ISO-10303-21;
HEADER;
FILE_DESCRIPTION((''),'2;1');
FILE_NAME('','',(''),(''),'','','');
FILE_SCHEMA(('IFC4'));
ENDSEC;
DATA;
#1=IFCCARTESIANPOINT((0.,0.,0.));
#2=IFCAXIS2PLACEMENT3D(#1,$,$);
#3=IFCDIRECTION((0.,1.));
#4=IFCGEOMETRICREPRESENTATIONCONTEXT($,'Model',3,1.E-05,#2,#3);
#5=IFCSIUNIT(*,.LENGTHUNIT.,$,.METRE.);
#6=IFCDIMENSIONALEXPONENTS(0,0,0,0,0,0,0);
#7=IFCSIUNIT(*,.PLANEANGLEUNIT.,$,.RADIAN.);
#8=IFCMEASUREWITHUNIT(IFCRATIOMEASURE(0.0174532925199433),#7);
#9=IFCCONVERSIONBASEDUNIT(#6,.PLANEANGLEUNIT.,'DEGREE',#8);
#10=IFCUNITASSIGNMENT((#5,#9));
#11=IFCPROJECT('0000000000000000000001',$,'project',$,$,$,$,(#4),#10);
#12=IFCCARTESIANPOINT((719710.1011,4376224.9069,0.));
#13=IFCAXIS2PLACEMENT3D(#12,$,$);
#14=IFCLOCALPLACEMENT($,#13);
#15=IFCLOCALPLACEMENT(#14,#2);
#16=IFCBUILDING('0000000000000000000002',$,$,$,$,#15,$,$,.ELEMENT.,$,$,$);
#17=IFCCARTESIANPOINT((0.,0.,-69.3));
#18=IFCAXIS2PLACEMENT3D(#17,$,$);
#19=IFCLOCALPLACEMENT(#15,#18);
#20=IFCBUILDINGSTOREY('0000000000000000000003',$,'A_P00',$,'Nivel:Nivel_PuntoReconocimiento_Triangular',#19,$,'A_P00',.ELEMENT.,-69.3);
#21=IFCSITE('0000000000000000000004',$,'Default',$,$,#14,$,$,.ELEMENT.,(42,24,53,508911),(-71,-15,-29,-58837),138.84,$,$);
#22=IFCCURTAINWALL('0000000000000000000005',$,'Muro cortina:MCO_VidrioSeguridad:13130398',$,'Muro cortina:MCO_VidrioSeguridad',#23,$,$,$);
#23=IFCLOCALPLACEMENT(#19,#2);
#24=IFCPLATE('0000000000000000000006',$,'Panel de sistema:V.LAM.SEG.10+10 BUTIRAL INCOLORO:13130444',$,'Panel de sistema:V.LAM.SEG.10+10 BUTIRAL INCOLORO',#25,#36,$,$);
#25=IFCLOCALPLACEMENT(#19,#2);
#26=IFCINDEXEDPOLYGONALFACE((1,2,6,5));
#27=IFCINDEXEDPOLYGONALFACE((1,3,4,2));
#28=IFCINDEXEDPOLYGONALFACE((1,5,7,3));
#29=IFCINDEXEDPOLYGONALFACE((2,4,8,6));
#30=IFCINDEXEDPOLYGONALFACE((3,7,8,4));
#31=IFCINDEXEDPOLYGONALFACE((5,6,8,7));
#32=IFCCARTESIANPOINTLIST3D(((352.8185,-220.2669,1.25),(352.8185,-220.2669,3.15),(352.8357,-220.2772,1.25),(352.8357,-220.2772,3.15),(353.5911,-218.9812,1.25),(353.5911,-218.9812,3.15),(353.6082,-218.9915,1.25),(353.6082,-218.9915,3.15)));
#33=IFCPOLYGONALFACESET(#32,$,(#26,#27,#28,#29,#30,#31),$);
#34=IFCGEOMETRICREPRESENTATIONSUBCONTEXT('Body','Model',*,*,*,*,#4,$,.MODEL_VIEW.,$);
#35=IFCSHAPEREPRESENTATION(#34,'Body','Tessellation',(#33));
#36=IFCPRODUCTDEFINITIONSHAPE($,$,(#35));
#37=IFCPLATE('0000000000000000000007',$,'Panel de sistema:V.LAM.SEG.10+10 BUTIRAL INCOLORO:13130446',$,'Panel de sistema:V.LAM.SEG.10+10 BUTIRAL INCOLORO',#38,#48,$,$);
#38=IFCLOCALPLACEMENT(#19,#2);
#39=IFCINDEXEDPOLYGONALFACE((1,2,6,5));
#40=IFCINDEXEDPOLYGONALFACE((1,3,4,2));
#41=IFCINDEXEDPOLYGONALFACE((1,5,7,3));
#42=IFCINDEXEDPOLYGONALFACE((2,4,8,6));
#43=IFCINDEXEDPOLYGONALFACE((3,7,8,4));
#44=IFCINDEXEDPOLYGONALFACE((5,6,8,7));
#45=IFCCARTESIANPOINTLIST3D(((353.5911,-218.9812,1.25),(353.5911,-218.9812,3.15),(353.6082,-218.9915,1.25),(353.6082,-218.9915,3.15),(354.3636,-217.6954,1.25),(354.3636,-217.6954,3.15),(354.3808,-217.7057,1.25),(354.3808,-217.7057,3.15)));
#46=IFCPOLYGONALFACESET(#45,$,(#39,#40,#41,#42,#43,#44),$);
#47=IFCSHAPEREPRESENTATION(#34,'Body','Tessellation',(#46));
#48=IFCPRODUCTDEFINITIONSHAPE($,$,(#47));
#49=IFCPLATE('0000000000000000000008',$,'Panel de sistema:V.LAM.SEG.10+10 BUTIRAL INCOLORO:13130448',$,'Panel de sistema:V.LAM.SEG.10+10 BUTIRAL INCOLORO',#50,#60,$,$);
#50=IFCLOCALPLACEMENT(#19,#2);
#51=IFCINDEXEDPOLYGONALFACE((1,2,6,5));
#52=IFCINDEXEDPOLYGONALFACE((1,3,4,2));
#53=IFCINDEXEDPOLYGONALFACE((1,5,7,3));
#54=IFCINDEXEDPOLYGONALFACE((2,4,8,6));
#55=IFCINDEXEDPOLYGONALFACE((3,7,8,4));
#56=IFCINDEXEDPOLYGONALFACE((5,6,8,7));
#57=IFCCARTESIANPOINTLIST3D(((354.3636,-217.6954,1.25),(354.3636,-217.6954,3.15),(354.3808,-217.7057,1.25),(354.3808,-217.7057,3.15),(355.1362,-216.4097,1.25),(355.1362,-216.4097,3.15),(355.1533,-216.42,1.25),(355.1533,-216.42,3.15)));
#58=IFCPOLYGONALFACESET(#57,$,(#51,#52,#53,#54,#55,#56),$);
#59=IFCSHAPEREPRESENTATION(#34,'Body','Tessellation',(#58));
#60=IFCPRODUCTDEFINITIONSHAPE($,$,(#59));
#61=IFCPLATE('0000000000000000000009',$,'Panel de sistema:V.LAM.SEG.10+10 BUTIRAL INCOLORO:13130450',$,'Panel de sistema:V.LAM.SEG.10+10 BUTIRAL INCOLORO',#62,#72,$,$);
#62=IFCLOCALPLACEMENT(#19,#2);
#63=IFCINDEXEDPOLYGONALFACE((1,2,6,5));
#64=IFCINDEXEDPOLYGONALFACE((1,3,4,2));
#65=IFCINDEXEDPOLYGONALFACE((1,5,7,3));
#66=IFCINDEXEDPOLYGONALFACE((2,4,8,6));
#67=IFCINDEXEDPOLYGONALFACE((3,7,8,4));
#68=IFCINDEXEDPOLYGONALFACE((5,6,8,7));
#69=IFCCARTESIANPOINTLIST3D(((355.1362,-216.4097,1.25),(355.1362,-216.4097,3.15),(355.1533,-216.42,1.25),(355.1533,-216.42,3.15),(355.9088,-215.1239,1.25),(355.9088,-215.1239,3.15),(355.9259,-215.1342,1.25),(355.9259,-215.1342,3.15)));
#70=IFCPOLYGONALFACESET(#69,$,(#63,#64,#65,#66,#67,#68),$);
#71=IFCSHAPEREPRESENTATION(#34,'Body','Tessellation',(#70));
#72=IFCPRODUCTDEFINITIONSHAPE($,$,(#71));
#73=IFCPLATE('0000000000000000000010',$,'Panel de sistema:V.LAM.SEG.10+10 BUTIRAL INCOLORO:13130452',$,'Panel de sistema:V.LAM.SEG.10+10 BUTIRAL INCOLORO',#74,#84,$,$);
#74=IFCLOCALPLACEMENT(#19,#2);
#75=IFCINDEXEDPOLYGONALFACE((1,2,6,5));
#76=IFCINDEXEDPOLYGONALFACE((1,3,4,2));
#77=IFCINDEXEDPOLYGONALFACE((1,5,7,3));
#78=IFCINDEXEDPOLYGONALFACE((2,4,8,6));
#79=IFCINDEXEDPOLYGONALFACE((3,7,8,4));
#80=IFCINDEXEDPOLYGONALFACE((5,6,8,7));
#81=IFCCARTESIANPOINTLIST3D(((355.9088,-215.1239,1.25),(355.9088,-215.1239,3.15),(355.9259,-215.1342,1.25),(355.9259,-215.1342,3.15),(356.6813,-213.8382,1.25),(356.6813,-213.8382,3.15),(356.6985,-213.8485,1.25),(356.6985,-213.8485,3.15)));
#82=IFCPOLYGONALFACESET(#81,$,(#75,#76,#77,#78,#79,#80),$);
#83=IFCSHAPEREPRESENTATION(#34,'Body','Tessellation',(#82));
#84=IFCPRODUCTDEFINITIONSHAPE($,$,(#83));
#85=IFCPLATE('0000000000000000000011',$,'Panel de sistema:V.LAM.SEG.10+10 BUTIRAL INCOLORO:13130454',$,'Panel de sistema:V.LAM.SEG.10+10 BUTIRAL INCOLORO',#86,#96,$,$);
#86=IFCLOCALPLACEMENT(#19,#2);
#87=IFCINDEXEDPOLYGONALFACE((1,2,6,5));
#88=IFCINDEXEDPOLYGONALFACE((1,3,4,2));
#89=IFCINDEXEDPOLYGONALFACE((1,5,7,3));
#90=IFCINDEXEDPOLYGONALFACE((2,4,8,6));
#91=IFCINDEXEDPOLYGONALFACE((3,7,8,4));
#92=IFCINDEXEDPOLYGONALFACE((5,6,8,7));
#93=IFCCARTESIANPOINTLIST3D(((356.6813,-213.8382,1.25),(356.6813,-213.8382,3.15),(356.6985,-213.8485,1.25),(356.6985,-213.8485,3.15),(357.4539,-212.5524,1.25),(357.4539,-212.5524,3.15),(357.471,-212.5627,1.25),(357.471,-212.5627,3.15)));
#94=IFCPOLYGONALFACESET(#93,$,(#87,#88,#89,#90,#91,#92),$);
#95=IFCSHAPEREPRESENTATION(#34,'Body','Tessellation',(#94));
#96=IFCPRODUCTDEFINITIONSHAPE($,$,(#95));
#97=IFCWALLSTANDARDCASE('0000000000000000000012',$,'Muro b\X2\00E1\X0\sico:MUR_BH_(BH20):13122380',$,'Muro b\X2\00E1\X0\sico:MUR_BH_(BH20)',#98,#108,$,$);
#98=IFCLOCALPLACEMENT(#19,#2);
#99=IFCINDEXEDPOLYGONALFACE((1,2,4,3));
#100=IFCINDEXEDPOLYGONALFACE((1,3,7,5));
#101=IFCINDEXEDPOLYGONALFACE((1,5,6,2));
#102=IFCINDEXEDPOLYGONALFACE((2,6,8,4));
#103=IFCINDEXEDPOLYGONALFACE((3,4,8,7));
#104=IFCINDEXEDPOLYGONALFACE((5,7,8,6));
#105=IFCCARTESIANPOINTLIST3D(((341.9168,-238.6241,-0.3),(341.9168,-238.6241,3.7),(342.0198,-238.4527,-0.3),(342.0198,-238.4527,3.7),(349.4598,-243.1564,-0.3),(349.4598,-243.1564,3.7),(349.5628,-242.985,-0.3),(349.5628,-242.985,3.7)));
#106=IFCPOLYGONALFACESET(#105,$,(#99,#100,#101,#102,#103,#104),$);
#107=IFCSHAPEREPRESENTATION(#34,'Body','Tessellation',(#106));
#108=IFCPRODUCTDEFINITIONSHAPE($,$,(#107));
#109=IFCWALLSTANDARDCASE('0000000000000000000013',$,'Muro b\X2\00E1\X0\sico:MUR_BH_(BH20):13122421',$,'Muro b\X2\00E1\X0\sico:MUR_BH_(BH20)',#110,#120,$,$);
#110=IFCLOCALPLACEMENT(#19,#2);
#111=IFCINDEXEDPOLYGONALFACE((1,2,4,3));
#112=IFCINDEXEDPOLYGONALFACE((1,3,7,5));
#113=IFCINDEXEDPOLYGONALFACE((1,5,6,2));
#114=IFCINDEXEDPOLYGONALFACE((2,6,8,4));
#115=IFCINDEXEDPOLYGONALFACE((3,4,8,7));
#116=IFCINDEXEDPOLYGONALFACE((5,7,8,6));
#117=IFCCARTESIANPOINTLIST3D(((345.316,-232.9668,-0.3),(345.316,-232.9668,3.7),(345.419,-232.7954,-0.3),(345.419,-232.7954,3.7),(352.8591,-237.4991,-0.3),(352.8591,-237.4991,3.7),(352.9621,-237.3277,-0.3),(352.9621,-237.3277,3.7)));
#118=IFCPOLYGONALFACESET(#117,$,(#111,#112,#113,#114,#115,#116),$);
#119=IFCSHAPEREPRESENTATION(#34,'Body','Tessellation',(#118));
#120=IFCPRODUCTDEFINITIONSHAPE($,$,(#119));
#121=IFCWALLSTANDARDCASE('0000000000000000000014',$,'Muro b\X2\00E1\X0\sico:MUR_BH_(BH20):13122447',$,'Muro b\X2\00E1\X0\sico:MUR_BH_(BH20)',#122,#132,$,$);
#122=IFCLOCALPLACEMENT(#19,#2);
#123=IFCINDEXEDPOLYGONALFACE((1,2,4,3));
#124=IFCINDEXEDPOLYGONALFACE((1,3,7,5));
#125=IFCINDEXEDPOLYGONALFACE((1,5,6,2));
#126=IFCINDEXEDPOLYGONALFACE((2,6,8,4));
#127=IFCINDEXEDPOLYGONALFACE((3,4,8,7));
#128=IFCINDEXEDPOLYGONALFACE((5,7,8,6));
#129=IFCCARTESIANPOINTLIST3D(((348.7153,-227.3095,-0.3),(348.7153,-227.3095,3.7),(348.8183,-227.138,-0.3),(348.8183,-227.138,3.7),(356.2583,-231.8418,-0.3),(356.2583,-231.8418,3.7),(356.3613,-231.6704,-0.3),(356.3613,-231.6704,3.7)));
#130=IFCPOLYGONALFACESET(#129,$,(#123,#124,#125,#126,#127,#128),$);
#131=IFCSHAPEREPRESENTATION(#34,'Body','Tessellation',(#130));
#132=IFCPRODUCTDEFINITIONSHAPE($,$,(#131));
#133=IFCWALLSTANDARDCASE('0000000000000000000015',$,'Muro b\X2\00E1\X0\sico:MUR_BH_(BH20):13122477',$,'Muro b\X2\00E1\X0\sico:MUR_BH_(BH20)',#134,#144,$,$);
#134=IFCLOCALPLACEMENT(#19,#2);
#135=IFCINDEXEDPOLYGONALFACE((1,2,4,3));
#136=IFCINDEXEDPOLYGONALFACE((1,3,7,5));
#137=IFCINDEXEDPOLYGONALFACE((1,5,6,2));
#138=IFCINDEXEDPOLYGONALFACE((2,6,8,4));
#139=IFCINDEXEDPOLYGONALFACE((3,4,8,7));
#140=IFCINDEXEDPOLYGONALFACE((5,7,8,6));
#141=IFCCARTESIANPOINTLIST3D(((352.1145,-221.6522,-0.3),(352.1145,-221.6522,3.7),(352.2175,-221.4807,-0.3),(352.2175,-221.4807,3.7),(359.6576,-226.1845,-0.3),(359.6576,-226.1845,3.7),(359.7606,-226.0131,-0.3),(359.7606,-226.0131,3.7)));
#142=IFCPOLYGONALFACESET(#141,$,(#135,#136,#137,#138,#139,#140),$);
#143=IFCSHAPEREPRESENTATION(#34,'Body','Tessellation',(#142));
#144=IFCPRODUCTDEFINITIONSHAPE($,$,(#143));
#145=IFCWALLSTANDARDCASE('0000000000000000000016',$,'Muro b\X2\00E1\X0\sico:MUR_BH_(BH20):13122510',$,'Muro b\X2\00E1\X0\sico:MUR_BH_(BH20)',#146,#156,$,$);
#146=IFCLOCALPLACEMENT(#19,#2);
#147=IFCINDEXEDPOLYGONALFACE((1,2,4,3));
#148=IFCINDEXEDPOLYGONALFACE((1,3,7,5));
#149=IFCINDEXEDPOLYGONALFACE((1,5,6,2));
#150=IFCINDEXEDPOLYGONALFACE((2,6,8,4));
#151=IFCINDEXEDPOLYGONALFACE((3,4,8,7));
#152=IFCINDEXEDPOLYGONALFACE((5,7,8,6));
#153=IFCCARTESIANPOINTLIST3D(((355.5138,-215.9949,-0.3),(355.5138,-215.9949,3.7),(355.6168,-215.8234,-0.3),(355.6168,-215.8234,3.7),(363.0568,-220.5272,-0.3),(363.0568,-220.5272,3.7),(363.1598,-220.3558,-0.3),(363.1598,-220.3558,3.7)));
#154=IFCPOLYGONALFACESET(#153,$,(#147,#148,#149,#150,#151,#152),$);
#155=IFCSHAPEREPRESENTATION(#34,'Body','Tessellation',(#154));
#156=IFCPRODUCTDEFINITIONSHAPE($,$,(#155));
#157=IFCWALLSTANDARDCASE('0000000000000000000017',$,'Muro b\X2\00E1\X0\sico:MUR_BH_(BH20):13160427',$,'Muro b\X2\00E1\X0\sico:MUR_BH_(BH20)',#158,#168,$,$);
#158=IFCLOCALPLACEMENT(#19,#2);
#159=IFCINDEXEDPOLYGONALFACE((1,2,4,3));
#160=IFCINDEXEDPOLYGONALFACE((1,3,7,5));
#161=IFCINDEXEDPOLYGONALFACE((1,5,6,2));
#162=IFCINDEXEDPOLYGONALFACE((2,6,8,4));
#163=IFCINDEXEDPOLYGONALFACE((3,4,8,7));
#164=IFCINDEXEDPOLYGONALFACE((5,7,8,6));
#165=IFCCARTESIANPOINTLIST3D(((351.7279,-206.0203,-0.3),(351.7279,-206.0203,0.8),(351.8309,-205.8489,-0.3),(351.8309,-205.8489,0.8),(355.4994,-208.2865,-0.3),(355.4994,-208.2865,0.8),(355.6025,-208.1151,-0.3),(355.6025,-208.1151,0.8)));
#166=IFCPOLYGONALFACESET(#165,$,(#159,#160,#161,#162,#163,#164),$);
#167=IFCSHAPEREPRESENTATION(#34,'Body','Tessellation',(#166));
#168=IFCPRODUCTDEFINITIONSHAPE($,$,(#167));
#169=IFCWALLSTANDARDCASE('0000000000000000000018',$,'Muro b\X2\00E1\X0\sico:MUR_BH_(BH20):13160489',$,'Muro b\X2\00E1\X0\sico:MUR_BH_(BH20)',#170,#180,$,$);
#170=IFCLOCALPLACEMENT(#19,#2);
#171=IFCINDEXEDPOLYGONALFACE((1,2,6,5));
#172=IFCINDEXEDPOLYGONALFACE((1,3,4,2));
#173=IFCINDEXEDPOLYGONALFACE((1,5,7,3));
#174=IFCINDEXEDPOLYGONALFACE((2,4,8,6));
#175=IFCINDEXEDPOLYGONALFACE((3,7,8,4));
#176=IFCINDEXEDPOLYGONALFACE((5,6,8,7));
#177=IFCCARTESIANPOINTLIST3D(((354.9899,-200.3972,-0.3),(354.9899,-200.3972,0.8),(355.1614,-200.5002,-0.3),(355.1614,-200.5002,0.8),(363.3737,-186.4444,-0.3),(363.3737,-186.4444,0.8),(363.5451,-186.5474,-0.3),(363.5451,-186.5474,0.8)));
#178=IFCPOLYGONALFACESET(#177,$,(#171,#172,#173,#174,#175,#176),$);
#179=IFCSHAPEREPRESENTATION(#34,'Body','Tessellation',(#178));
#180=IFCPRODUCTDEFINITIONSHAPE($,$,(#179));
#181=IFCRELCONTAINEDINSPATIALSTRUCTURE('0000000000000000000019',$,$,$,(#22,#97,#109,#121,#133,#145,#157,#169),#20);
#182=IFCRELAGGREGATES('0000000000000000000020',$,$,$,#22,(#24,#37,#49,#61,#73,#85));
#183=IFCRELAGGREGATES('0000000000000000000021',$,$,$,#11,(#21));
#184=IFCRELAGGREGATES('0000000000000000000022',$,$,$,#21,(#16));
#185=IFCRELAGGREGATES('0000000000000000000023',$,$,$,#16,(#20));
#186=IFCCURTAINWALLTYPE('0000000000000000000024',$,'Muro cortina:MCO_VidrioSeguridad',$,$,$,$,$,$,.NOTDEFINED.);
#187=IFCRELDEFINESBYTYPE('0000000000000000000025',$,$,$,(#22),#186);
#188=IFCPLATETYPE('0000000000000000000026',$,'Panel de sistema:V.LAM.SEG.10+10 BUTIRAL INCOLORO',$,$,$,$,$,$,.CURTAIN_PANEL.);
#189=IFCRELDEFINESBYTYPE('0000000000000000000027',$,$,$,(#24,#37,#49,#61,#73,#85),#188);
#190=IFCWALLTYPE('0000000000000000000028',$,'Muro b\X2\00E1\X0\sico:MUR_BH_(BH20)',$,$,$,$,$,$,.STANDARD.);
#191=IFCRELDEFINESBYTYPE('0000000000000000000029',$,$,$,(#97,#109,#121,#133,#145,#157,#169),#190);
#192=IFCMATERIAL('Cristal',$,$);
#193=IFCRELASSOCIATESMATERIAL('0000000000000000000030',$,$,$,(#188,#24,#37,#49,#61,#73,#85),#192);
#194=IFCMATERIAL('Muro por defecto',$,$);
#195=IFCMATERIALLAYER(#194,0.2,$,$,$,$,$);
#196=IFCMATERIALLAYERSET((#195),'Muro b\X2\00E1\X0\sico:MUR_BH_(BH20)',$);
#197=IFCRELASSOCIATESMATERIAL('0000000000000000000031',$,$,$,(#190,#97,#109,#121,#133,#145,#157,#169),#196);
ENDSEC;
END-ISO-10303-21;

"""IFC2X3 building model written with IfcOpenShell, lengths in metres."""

from ifc_helpers import new_model, entity, si_unit, converted_unit, direction, frame, frame_2d, origin, origin_2d_with_axis, place, context, subcontext, project, spatial, rectangle, extrude, source, transform, mapped, material, layer, layer_set, layer_usage, type_object, type_shapes, element, aggregate, save


model = new_model("IFC2X3")

# Units and contexts
model_context = context("Model", 3, precision=1e-05, world=origin(), true_north=direction((0.0, 1.0)))
body_context = subcontext(model_context, "Body", "Model", "MODEL_VIEW")
ifc_project = project(units=[si_unit("LENGTHUNIT", "METRE"), converted_unit("PLANEANGLEUNIT", "DEGREE", entity("IfcRatioMeasure", 0.0174532925199433), si_unit("PLANEANGLEUNIT", "RADIAN"), dimensions=[0, 0, 0, 0, 0, 0, 0])], contexts=[model_context])

# Site, building, storey
site_placement = place(None, frame((719710.1011, 4376224.9069, 0.0)))
site = spatial("IfcSite", under=ifc_project, at=site_placement, Name="Default", CompositionType="ELEMENT", RefLatitude=(42, 24, 53, 508911), RefLongitude=(-71, -15, -29, -58837), RefElevation=138.84)
building_placement = place(site_placement, origin())
building = spatial("IfcBuilding", under=site, at=building_placement, CompositionType="ELEMENT")
storey_placement = place(building_placement, frame((0.0, 0.0, -69.3)))
storey = spatial("IfcBuildingStorey", under=building, at=storey_placement, Name="A_P00", ObjectType="Nivel:Nivel_PuntoReconocimiento_Triangular", LongName="A_P00", CompositionType="ELEMENT", Elevation=-69.3)

# Curtain wall, plates
curtain_wall_type = type_object("IfcCurtainWallType", Name="Muro cortina:MCO_VidrioSeguridad", PredefinedType="NOTDEFINED")
curtain_wall_placement = place(storey_placement, frame((0.0, 0.0, 69.3)))
curtain_wall = element("IfcCurtainWall", 1, at=curtain_wall_placement, inside=storey, type_object=curtain_wall_type, Name="Muro cortina:MCO_VidrioSeguridad:13130398", ObjectType="Muro cortina:MCO_VidrioSeguridad")
ifc_material_1 = material(Name="Cristal")
plate_type = type_object("IfcPlateType", Name="Panel de sistema:V.LAM.SEG.10+10 BUTIRAL INCOLORO", PredefinedType="CURTAIN_PANEL", material=ifc_material_1)
shared_shape = source(origin(), body_context, "Body", "SweptSolid", [
    extrude(rectangle(XDim=0.02, YDim=1.5, at=origin_2d_with_axis()), frame((0.0, 0.0, 0.0), z_axis=(0.0, 0.0, 1.0), x_axis=(0.0, 1.0, 0.0)), (0.0, 0.0, 1.0), 1.9),
])
type_shapes(plate_type, [shared_shape])
plate_1_placement = place(curtain_wall_placement, frame((353.2134, -219.6292, -68.05), z_axis=(0.0, 0.0, 1.0), x_axis=(0.515038, 0.857167, 0.0)))
plate_1 = element("IfcPlate", 2, at=plate_1_placement, type_object=plate_type, material=ifc_material_1, Name="Panel de sistema:V.LAM.SEG.10+10 BUTIRAL INCOLORO:13130444", ObjectType="Panel de sistema:V.LAM.SEG.10+10 BUTIRAL INCOLORO", context=body_context, shape_type="MappedRepresentation", body=[
    mapped(shared_shape, transform((0.0, 0.0, 0.0), scale=1.0)),
])
plate_2_placement = place(curtain_wall_placement, frame((353.9859, -218.3434, -68.05), z_axis=(0.0, 0.0, 1.0), x_axis=(0.515038, 0.857167, 0.0)))
plate_2 = element("IfcPlate", 3, at=plate_2_placement, type_object=plate_type, material=ifc_material_1, Name="Panel de sistema:V.LAM.SEG.10+10 BUTIRAL INCOLORO:13130446", ObjectType="Panel de sistema:V.LAM.SEG.10+10 BUTIRAL INCOLORO", context=body_context, shape_type="MappedRepresentation", body=[
    mapped(shared_shape, transform((0.0, 0.0, 0.0), scale=1.0)),
])
plate_3_placement = place(curtain_wall_placement, frame((354.7585, -217.0577, -68.05), z_axis=(0.0, 0.0, 1.0), x_axis=(0.515038, 0.857167, 0.0)))
plate_3 = element("IfcPlate", 4, at=plate_3_placement, type_object=plate_type, material=ifc_material_1, Name="Panel de sistema:V.LAM.SEG.10+10 BUTIRAL INCOLORO:13130448", ObjectType="Panel de sistema:V.LAM.SEG.10+10 BUTIRAL INCOLORO", context=body_context, shape_type="MappedRepresentation", body=[
    mapped(shared_shape, transform((0.0, 0.0, 0.0), scale=1.0)),
])
plate_4_placement = place(curtain_wall_placement, frame((355.5311, -215.7719, -68.05), z_axis=(0.0, 0.0, 1.0), x_axis=(0.515038, 0.857167, 0.0)))
plate_4 = element("IfcPlate", 5, at=plate_4_placement, type_object=plate_type, material=ifc_material_1, Name="Panel de sistema:V.LAM.SEG.10+10 BUTIRAL INCOLORO:13130450", ObjectType="Panel de sistema:V.LAM.SEG.10+10 BUTIRAL INCOLORO", context=body_context, shape_type="MappedRepresentation", body=[
    mapped(shared_shape, transform((0.0, 0.0, 0.0), scale=1.0)),
])
plate_5_placement = place(curtain_wall_placement, frame((356.3036, -214.4862, -68.05), z_axis=(0.0, 0.0, 1.0), x_axis=(0.515038, 0.857167, 0.0)))
plate_5 = element("IfcPlate", 6, at=plate_5_placement, type_object=plate_type, material=ifc_material_1, Name="Panel de sistema:V.LAM.SEG.10+10 BUTIRAL INCOLORO:13130452", ObjectType="Panel de sistema:V.LAM.SEG.10+10 BUTIRAL INCOLORO", context=body_context, shape_type="MappedRepresentation", body=[
    mapped(shared_shape, transform((0.0, 0.0, 0.0), scale=1.0)),
])
plate_6_placement = place(curtain_wall_placement, frame((357.0762, -213.2004, -68.05), z_axis=(0.0, 0.0, 1.0), x_axis=(0.515038, 0.857167, 0.0)))
plate_6 = element("IfcPlate", 7, at=plate_6_placement, type_object=plate_type, material=ifc_material_1, Name="Panel de sistema:V.LAM.SEG.10+10 BUTIRAL INCOLORO:13130454", ObjectType="Panel de sistema:V.LAM.SEG.10+10 BUTIRAL INCOLORO", context=body_context, shape_type="MappedRepresentation", body=[
    mapped(shared_shape, transform((0.0, 0.0, 0.0), scale=1.0)),
])
aggregate(curtain_wall, [plate_1, plate_2, plate_3, plate_4, plate_5, plate_6])

# Walls
ifc_material_2 = material(Name="Muro por defecto")
ifc_layer = layer(ifc_material_2, 0.2)
ifc_layer_set = layer_set([ifc_layer], Name="Muro básico:MUR_BH_(BH20)")
ifc_layer_usage_1 = layer_usage(ifc_layer_set, "AXIS2", "NEGATIVE", 0.1)
wall_type = type_object("IfcWallType", Name="Muro básico:MUR_BH_(BH20)", PredefinedType="STANDARD", material=ifc_layer_set)
wall_1_placement = place(storey_placement, frame((341.9683, -238.5384, -0.3), z_axis=(0.0, 0.0, 1.0), x_axis=(0.857167, -0.515038, 0.0)))
element("IfcWallStandardCase", 8, at=wall_1_placement, inside=storey, type_object=wall_type, material=ifc_layer_usage_1, Name="Muro básico:MUR_BH_(BH20):13122380", ObjectType="Muro básico:MUR_BH_(BH20)", context=body_context, shape_type="SweptSolid", body=[
    extrude(rectangle(XDim=8.8, YDim=0.2, at=frame_2d((4.4, 0.0), x_axis=(-1.0, 0.0))), origin(), (0.0, 0.0, 1.0), 4.0),
])
ifc_layer_usage_2 = layer_usage(ifc_layer_set, "AXIS2", "NEGATIVE", 0.1)
wall_2_placement = place(storey_placement, frame((345.3675, -232.8811, -0.3), z_axis=(0.0, 0.0, 1.0), x_axis=(0.857167, -0.515038, 0.0)))
element("IfcWallStandardCase", 9, at=wall_2_placement, inside=storey, type_object=wall_type, material=ifc_layer_usage_2, Name="Muro básico:MUR_BH_(BH20):13122421", ObjectType="Muro básico:MUR_BH_(BH20)", context=body_context, shape_type="SweptSolid", body=[
    extrude(rectangle(XDim=8.8, YDim=0.2, at=frame_2d((4.4, 0.0), x_axis=(-1.0, 0.0))), origin(), (0.0, 0.0, 1.0), 4.0),
])
ifc_layer_usage_3 = layer_usage(ifc_layer_set, "AXIS2", "NEGATIVE", 0.1)
wall_3_placement = place(storey_placement, frame((348.7668, -227.2238, -0.3), z_axis=(0.0, 0.0, 1.0), x_axis=(0.857167, -0.515038, 0.0)))
element("IfcWallStandardCase", 10, at=wall_3_placement, inside=storey, type_object=wall_type, material=ifc_layer_usage_3, Name="Muro básico:MUR_BH_(BH20):13122447", ObjectType="Muro básico:MUR_BH_(BH20)", context=body_context, shape_type="SweptSolid", body=[
    extrude(rectangle(XDim=8.8, YDim=0.2, at=frame_2d((4.4, 0.0), x_axis=(-1.0, 0.0))), origin(), (0.0, 0.0, 1.0), 4.0),
])
ifc_layer_usage_4 = layer_usage(ifc_layer_set, "AXIS2", "NEGATIVE", 0.1)
wall_4_placement = place(storey_placement, frame((352.166, -221.5665, -0.3), z_axis=(0.0, 0.0, 1.0), x_axis=(0.857167, -0.515038, 0.0)))
element("IfcWallStandardCase", 11, at=wall_4_placement, inside=storey, type_object=wall_type, material=ifc_layer_usage_4, Name="Muro básico:MUR_BH_(BH20):13122477", ObjectType="Muro básico:MUR_BH_(BH20)", context=body_context, shape_type="SweptSolid", body=[
    extrude(rectangle(XDim=8.8, YDim=0.2, at=frame_2d((4.4, 0.0), x_axis=(-1.0, 0.0))), origin(), (0.0, 0.0, 1.0), 4.0),
])
ifc_layer_usage_5 = layer_usage(ifc_layer_set, "AXIS2", "NEGATIVE", 0.1)
wall_5_placement = place(storey_placement, frame((355.5653, -215.9092, -0.3), z_axis=(0.0, 0.0, 1.0), x_axis=(0.857167, -0.515038, 0.0)))
element("IfcWallStandardCase", 12, at=wall_5_placement, inside=storey, type_object=wall_type, material=ifc_layer_usage_5, Name="Muro básico:MUR_BH_(BH20):13122510", ObjectType="Muro básico:MUR_BH_(BH20)", context=body_context, shape_type="SweptSolid", body=[
    extrude(rectangle(XDim=8.8, YDim=0.2, at=frame_2d((4.4, 0.0), x_axis=(-1.0, 0.0))), origin(), (0.0, 0.0, 1.0), 4.0),
])
ifc_layer_usage_6 = layer_usage(ifc_layer_set, "AXIS2", "POSITIVE", -0.1)
wall_6_placement = place(storey_placement, frame((355.5509, -208.2008, -0.3), z_axis=(0.0, 0.0, 1.0), x_axis=(-0.857167, 0.515038, 0.0)))
element("IfcWallStandardCase", 13, at=wall_6_placement, inside=storey, type_object=wall_type, material=ifc_layer_usage_6, Name="Muro básico:MUR_BH_(BH20):13160427", ObjectType="Muro básico:MUR_BH_(BH20)", context=body_context, shape_type="SweptSolid", body=[
    extrude(rectangle(XDim=4.4, YDim=0.2, at=frame_2d((2.2, 0.0), x_axis=(-1.0, 0.0))), origin(), (0.0, 0.0, 1.0), 1.1),
])
ifc_layer_usage_7 = layer_usage(ifc_layer_set, "AXIS2", "NEGATIVE", 0.1)
wall_7_placement = place(storey_placement, frame((355.0757, -200.4487, -0.3), z_axis=(0.0, 0.0, 1.0), x_axis=(0.515038, 0.857167, 0.0)))
element("IfcWallStandardCase", 14, at=wall_7_placement, inside=storey, type_object=wall_type, material=ifc_layer_usage_7, Name="Muro básico:MUR_BH_(BH20):13160489", ObjectType="Muro básico:MUR_BH_(BH20)", context=body_context, shape_type="SweptSolid", body=[
    extrude(rectangle(XDim=16.2778, YDim=0.2, at=frame_2d((8.1389, 0.0), x_axis=(-1.0, 0.0))), origin(), (0.0, 0.0, 1.0), 1.1),
])

save(model, "model.ifc")
